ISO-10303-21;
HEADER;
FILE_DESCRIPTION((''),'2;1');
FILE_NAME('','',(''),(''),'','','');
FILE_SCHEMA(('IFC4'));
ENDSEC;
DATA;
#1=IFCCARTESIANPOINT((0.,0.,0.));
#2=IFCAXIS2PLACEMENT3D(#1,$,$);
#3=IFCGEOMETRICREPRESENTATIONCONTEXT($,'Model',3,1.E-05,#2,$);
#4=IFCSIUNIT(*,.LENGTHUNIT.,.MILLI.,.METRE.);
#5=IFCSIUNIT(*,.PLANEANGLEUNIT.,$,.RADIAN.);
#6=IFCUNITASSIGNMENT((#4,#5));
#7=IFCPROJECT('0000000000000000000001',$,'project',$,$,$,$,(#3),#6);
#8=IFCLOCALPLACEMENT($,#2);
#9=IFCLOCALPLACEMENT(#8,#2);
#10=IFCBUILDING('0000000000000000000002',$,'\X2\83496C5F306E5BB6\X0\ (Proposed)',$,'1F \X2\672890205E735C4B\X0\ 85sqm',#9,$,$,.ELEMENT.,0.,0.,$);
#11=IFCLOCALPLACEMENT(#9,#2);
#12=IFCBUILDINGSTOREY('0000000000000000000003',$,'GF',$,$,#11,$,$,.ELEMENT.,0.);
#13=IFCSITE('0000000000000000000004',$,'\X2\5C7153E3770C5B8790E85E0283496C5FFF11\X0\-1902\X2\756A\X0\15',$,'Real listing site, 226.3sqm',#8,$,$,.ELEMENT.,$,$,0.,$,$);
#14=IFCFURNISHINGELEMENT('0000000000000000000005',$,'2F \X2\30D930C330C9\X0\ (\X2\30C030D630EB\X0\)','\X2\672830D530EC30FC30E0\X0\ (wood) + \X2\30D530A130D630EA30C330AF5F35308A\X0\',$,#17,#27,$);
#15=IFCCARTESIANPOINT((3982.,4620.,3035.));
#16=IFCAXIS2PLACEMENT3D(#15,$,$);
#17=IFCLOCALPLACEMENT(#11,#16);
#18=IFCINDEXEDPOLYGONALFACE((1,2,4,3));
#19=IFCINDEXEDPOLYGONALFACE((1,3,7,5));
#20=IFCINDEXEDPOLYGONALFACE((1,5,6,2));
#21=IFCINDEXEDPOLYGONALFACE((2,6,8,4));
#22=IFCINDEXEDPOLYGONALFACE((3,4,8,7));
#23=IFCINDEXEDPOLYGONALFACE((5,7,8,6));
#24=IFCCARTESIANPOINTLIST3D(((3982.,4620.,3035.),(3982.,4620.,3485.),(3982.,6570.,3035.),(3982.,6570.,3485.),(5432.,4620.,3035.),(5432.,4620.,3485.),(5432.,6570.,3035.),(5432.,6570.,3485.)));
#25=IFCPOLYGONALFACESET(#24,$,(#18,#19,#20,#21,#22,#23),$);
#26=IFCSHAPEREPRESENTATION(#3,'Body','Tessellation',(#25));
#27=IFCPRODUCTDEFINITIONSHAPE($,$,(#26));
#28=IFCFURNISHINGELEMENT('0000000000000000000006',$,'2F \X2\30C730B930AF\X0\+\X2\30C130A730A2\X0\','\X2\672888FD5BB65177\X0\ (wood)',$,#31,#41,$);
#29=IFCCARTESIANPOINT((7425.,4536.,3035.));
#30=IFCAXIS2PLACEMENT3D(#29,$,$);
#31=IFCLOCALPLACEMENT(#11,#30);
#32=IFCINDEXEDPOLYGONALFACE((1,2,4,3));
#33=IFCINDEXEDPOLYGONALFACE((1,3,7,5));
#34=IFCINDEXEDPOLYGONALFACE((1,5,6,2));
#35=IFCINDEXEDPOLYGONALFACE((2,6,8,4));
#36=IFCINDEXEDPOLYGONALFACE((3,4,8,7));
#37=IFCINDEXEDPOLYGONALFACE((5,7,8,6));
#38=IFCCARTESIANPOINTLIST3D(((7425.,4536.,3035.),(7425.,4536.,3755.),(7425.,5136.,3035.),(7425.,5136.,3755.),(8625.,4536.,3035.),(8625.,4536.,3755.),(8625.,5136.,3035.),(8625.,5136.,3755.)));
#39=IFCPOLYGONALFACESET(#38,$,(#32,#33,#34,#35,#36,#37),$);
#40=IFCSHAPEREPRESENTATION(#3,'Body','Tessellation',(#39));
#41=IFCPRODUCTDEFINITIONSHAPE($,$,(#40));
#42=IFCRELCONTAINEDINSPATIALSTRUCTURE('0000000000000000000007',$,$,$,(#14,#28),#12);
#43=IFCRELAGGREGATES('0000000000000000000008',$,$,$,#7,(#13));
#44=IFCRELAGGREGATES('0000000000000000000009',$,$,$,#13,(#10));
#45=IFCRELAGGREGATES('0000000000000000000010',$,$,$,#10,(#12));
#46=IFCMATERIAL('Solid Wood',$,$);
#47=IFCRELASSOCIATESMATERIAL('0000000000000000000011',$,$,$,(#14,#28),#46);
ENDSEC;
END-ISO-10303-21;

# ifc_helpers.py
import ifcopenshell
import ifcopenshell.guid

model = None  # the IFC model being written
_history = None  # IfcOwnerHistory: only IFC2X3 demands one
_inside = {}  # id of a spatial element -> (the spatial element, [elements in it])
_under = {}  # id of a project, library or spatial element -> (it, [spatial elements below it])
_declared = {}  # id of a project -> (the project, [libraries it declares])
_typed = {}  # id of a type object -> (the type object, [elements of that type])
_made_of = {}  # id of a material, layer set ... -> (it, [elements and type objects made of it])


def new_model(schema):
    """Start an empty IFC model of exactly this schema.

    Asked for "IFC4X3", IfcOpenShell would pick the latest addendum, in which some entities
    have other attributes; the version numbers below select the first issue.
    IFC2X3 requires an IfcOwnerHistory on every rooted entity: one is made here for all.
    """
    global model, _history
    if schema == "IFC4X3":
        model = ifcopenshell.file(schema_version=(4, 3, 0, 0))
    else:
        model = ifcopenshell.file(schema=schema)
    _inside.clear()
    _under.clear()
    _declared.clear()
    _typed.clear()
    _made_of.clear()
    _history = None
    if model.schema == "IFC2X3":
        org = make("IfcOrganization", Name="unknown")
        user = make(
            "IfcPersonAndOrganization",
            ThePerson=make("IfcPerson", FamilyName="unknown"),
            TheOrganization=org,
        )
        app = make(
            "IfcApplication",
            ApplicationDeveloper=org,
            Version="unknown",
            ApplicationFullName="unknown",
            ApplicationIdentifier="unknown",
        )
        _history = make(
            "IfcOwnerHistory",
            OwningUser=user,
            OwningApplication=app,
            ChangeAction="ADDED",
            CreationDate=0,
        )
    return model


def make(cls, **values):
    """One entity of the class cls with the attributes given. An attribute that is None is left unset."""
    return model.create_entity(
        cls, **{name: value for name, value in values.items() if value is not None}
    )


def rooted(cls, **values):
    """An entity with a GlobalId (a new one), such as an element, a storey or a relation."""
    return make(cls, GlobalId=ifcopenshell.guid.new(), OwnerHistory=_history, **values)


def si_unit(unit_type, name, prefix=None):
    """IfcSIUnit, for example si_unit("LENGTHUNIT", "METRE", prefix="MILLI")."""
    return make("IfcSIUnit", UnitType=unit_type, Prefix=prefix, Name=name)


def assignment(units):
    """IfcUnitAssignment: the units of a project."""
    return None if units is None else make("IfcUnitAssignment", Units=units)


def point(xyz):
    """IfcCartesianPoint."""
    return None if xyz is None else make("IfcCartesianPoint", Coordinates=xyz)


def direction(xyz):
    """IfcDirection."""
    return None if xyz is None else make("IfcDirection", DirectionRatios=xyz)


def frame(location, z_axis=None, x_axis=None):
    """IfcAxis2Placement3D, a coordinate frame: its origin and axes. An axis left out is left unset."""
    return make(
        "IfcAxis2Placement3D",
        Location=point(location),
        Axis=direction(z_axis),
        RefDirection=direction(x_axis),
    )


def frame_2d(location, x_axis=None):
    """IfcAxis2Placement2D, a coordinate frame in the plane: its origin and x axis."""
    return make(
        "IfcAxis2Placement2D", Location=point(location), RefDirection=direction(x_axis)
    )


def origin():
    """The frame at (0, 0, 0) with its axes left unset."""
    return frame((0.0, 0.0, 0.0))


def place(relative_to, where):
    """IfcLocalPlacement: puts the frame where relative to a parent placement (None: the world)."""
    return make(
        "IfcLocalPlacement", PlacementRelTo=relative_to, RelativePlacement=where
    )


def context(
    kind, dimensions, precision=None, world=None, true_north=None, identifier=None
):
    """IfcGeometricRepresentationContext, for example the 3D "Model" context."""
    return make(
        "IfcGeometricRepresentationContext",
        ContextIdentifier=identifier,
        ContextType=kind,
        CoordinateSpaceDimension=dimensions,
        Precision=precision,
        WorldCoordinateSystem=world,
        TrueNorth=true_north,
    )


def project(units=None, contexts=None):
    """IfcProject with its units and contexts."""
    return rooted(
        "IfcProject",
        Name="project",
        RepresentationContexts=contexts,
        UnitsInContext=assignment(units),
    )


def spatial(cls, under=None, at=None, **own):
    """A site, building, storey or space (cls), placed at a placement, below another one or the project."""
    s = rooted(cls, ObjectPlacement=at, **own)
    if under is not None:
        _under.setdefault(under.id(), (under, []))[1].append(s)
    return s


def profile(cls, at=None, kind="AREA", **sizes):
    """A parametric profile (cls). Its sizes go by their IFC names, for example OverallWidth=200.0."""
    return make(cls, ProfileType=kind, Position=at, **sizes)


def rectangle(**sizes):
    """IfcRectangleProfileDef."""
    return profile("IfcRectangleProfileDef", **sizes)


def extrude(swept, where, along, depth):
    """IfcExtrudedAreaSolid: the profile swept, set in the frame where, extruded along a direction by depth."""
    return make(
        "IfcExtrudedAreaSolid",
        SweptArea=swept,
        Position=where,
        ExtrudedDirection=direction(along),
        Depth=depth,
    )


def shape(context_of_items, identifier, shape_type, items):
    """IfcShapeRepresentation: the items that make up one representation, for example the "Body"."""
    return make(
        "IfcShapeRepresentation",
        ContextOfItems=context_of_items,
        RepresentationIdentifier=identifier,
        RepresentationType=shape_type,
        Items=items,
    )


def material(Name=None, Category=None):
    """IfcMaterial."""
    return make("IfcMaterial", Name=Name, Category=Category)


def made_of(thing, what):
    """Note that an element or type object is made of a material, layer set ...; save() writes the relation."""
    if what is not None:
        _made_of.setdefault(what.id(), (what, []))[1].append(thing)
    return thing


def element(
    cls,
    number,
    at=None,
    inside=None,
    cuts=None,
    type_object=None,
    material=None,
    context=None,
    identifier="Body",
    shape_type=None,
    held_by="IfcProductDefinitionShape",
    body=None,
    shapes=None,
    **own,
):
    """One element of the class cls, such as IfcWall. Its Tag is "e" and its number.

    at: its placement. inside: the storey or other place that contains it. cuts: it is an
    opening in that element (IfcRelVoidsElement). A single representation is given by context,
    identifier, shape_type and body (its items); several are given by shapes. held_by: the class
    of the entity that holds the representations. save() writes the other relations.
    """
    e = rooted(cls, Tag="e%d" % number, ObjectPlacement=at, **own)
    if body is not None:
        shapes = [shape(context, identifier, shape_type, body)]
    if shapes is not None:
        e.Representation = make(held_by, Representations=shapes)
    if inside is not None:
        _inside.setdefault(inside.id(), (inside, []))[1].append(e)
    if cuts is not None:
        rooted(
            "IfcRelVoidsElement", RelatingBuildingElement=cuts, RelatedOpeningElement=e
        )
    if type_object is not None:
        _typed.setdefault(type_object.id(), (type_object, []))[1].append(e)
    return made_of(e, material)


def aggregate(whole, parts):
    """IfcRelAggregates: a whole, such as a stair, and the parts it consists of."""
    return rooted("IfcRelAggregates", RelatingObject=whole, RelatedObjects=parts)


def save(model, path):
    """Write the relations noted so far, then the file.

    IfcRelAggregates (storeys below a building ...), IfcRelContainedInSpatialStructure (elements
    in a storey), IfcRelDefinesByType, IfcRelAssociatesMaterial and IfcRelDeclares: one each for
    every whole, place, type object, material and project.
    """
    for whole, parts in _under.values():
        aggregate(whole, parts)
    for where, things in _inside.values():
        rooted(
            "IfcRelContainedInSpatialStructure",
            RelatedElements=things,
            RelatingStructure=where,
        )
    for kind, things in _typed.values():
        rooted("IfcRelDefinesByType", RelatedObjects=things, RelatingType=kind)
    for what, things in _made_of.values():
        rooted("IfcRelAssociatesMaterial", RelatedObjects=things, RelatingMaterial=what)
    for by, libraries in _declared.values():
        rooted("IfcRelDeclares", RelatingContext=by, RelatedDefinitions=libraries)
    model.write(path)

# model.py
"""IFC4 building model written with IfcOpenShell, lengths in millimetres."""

from ifc_helpers import new_model, si_unit, frame, frame_2d, origin, place, context, project, spatial, rectangle, extrude, material, element, save


model = new_model("IFC4")

# Units and contexts
model_context = context("Model", 3, precision=1e-05, world=origin())
ifc_project = project(units=[si_unit("LENGTHUNIT", "METRE", prefix="MILLI"), si_unit("PLANEANGLEUNIT", "RADIAN")], contexts=[model_context])

# Site, building, storey
site_placement = place(None, origin())
site = spatial("IfcSite", under=ifc_project, at=site_placement, Name="山口県宇部市草江１-1902番15", ObjectType="Real listing site, 226.3sqm", CompositionType="ELEMENT", RefElevation=0.0)
building_placement = place(site_placement, origin())
building = spatial("IfcBuilding", under=site, at=building_placement, Name="草江の家 (Proposed)", ObjectType="1F 木造平屋 85sqm", CompositionType="ELEMENT", ElevationOfRefHeight=0.0, ElevationOfTerrain=0.0)
storey_placement = place(building_placement, origin())
storey = spatial("IfcBuildingStorey", under=building, at=storey_placement, Name="GF", CompositionType="ELEMENT", Elevation=0.0)

# Shared definitions
ifc_material_1 = material(Name="Solid Wood")

# Furnishing elements
furnishing_1_placement = place(storey_placement, frame((3982.0, 4620.0, 3035.0)))
element("IfcFurnishingElement", 1, at=furnishing_1_placement, inside=storey, material=ifc_material_1, Name="2F ベッド (ダブル)", Description="木フレーム (wood) + ファブリック張り", context=model_context, shape_type="SweptSolid", body=[
    extrude(rectangle(XDim=1450.0, YDim=1950.0, at=frame_2d((725.0, 975.0))), frame((3982.0, 4620.0, 3035.0)), (0.0, 0.0, 1.0), 450.0),
])
furnishing_2_placement = place(storey_placement, frame((7425.0, 4536.0, 3035.0)))
element("IfcFurnishingElement", 2, at=furnishing_2_placement, inside=storey, material=ifc_material_1, Name="2F デスク+チェア", Description="木製家具 (wood)", context=model_context, shape_type="SweptSolid", body=[
    extrude(rectangle(XDim=1200.0, YDim=600.0, at=frame_2d((600.0, 300.0))), frame((7425.0, 4536.0, 3035.0)), (0.0, 0.0, 1.0), 720.0),
])

save(model, "model.ifc")
